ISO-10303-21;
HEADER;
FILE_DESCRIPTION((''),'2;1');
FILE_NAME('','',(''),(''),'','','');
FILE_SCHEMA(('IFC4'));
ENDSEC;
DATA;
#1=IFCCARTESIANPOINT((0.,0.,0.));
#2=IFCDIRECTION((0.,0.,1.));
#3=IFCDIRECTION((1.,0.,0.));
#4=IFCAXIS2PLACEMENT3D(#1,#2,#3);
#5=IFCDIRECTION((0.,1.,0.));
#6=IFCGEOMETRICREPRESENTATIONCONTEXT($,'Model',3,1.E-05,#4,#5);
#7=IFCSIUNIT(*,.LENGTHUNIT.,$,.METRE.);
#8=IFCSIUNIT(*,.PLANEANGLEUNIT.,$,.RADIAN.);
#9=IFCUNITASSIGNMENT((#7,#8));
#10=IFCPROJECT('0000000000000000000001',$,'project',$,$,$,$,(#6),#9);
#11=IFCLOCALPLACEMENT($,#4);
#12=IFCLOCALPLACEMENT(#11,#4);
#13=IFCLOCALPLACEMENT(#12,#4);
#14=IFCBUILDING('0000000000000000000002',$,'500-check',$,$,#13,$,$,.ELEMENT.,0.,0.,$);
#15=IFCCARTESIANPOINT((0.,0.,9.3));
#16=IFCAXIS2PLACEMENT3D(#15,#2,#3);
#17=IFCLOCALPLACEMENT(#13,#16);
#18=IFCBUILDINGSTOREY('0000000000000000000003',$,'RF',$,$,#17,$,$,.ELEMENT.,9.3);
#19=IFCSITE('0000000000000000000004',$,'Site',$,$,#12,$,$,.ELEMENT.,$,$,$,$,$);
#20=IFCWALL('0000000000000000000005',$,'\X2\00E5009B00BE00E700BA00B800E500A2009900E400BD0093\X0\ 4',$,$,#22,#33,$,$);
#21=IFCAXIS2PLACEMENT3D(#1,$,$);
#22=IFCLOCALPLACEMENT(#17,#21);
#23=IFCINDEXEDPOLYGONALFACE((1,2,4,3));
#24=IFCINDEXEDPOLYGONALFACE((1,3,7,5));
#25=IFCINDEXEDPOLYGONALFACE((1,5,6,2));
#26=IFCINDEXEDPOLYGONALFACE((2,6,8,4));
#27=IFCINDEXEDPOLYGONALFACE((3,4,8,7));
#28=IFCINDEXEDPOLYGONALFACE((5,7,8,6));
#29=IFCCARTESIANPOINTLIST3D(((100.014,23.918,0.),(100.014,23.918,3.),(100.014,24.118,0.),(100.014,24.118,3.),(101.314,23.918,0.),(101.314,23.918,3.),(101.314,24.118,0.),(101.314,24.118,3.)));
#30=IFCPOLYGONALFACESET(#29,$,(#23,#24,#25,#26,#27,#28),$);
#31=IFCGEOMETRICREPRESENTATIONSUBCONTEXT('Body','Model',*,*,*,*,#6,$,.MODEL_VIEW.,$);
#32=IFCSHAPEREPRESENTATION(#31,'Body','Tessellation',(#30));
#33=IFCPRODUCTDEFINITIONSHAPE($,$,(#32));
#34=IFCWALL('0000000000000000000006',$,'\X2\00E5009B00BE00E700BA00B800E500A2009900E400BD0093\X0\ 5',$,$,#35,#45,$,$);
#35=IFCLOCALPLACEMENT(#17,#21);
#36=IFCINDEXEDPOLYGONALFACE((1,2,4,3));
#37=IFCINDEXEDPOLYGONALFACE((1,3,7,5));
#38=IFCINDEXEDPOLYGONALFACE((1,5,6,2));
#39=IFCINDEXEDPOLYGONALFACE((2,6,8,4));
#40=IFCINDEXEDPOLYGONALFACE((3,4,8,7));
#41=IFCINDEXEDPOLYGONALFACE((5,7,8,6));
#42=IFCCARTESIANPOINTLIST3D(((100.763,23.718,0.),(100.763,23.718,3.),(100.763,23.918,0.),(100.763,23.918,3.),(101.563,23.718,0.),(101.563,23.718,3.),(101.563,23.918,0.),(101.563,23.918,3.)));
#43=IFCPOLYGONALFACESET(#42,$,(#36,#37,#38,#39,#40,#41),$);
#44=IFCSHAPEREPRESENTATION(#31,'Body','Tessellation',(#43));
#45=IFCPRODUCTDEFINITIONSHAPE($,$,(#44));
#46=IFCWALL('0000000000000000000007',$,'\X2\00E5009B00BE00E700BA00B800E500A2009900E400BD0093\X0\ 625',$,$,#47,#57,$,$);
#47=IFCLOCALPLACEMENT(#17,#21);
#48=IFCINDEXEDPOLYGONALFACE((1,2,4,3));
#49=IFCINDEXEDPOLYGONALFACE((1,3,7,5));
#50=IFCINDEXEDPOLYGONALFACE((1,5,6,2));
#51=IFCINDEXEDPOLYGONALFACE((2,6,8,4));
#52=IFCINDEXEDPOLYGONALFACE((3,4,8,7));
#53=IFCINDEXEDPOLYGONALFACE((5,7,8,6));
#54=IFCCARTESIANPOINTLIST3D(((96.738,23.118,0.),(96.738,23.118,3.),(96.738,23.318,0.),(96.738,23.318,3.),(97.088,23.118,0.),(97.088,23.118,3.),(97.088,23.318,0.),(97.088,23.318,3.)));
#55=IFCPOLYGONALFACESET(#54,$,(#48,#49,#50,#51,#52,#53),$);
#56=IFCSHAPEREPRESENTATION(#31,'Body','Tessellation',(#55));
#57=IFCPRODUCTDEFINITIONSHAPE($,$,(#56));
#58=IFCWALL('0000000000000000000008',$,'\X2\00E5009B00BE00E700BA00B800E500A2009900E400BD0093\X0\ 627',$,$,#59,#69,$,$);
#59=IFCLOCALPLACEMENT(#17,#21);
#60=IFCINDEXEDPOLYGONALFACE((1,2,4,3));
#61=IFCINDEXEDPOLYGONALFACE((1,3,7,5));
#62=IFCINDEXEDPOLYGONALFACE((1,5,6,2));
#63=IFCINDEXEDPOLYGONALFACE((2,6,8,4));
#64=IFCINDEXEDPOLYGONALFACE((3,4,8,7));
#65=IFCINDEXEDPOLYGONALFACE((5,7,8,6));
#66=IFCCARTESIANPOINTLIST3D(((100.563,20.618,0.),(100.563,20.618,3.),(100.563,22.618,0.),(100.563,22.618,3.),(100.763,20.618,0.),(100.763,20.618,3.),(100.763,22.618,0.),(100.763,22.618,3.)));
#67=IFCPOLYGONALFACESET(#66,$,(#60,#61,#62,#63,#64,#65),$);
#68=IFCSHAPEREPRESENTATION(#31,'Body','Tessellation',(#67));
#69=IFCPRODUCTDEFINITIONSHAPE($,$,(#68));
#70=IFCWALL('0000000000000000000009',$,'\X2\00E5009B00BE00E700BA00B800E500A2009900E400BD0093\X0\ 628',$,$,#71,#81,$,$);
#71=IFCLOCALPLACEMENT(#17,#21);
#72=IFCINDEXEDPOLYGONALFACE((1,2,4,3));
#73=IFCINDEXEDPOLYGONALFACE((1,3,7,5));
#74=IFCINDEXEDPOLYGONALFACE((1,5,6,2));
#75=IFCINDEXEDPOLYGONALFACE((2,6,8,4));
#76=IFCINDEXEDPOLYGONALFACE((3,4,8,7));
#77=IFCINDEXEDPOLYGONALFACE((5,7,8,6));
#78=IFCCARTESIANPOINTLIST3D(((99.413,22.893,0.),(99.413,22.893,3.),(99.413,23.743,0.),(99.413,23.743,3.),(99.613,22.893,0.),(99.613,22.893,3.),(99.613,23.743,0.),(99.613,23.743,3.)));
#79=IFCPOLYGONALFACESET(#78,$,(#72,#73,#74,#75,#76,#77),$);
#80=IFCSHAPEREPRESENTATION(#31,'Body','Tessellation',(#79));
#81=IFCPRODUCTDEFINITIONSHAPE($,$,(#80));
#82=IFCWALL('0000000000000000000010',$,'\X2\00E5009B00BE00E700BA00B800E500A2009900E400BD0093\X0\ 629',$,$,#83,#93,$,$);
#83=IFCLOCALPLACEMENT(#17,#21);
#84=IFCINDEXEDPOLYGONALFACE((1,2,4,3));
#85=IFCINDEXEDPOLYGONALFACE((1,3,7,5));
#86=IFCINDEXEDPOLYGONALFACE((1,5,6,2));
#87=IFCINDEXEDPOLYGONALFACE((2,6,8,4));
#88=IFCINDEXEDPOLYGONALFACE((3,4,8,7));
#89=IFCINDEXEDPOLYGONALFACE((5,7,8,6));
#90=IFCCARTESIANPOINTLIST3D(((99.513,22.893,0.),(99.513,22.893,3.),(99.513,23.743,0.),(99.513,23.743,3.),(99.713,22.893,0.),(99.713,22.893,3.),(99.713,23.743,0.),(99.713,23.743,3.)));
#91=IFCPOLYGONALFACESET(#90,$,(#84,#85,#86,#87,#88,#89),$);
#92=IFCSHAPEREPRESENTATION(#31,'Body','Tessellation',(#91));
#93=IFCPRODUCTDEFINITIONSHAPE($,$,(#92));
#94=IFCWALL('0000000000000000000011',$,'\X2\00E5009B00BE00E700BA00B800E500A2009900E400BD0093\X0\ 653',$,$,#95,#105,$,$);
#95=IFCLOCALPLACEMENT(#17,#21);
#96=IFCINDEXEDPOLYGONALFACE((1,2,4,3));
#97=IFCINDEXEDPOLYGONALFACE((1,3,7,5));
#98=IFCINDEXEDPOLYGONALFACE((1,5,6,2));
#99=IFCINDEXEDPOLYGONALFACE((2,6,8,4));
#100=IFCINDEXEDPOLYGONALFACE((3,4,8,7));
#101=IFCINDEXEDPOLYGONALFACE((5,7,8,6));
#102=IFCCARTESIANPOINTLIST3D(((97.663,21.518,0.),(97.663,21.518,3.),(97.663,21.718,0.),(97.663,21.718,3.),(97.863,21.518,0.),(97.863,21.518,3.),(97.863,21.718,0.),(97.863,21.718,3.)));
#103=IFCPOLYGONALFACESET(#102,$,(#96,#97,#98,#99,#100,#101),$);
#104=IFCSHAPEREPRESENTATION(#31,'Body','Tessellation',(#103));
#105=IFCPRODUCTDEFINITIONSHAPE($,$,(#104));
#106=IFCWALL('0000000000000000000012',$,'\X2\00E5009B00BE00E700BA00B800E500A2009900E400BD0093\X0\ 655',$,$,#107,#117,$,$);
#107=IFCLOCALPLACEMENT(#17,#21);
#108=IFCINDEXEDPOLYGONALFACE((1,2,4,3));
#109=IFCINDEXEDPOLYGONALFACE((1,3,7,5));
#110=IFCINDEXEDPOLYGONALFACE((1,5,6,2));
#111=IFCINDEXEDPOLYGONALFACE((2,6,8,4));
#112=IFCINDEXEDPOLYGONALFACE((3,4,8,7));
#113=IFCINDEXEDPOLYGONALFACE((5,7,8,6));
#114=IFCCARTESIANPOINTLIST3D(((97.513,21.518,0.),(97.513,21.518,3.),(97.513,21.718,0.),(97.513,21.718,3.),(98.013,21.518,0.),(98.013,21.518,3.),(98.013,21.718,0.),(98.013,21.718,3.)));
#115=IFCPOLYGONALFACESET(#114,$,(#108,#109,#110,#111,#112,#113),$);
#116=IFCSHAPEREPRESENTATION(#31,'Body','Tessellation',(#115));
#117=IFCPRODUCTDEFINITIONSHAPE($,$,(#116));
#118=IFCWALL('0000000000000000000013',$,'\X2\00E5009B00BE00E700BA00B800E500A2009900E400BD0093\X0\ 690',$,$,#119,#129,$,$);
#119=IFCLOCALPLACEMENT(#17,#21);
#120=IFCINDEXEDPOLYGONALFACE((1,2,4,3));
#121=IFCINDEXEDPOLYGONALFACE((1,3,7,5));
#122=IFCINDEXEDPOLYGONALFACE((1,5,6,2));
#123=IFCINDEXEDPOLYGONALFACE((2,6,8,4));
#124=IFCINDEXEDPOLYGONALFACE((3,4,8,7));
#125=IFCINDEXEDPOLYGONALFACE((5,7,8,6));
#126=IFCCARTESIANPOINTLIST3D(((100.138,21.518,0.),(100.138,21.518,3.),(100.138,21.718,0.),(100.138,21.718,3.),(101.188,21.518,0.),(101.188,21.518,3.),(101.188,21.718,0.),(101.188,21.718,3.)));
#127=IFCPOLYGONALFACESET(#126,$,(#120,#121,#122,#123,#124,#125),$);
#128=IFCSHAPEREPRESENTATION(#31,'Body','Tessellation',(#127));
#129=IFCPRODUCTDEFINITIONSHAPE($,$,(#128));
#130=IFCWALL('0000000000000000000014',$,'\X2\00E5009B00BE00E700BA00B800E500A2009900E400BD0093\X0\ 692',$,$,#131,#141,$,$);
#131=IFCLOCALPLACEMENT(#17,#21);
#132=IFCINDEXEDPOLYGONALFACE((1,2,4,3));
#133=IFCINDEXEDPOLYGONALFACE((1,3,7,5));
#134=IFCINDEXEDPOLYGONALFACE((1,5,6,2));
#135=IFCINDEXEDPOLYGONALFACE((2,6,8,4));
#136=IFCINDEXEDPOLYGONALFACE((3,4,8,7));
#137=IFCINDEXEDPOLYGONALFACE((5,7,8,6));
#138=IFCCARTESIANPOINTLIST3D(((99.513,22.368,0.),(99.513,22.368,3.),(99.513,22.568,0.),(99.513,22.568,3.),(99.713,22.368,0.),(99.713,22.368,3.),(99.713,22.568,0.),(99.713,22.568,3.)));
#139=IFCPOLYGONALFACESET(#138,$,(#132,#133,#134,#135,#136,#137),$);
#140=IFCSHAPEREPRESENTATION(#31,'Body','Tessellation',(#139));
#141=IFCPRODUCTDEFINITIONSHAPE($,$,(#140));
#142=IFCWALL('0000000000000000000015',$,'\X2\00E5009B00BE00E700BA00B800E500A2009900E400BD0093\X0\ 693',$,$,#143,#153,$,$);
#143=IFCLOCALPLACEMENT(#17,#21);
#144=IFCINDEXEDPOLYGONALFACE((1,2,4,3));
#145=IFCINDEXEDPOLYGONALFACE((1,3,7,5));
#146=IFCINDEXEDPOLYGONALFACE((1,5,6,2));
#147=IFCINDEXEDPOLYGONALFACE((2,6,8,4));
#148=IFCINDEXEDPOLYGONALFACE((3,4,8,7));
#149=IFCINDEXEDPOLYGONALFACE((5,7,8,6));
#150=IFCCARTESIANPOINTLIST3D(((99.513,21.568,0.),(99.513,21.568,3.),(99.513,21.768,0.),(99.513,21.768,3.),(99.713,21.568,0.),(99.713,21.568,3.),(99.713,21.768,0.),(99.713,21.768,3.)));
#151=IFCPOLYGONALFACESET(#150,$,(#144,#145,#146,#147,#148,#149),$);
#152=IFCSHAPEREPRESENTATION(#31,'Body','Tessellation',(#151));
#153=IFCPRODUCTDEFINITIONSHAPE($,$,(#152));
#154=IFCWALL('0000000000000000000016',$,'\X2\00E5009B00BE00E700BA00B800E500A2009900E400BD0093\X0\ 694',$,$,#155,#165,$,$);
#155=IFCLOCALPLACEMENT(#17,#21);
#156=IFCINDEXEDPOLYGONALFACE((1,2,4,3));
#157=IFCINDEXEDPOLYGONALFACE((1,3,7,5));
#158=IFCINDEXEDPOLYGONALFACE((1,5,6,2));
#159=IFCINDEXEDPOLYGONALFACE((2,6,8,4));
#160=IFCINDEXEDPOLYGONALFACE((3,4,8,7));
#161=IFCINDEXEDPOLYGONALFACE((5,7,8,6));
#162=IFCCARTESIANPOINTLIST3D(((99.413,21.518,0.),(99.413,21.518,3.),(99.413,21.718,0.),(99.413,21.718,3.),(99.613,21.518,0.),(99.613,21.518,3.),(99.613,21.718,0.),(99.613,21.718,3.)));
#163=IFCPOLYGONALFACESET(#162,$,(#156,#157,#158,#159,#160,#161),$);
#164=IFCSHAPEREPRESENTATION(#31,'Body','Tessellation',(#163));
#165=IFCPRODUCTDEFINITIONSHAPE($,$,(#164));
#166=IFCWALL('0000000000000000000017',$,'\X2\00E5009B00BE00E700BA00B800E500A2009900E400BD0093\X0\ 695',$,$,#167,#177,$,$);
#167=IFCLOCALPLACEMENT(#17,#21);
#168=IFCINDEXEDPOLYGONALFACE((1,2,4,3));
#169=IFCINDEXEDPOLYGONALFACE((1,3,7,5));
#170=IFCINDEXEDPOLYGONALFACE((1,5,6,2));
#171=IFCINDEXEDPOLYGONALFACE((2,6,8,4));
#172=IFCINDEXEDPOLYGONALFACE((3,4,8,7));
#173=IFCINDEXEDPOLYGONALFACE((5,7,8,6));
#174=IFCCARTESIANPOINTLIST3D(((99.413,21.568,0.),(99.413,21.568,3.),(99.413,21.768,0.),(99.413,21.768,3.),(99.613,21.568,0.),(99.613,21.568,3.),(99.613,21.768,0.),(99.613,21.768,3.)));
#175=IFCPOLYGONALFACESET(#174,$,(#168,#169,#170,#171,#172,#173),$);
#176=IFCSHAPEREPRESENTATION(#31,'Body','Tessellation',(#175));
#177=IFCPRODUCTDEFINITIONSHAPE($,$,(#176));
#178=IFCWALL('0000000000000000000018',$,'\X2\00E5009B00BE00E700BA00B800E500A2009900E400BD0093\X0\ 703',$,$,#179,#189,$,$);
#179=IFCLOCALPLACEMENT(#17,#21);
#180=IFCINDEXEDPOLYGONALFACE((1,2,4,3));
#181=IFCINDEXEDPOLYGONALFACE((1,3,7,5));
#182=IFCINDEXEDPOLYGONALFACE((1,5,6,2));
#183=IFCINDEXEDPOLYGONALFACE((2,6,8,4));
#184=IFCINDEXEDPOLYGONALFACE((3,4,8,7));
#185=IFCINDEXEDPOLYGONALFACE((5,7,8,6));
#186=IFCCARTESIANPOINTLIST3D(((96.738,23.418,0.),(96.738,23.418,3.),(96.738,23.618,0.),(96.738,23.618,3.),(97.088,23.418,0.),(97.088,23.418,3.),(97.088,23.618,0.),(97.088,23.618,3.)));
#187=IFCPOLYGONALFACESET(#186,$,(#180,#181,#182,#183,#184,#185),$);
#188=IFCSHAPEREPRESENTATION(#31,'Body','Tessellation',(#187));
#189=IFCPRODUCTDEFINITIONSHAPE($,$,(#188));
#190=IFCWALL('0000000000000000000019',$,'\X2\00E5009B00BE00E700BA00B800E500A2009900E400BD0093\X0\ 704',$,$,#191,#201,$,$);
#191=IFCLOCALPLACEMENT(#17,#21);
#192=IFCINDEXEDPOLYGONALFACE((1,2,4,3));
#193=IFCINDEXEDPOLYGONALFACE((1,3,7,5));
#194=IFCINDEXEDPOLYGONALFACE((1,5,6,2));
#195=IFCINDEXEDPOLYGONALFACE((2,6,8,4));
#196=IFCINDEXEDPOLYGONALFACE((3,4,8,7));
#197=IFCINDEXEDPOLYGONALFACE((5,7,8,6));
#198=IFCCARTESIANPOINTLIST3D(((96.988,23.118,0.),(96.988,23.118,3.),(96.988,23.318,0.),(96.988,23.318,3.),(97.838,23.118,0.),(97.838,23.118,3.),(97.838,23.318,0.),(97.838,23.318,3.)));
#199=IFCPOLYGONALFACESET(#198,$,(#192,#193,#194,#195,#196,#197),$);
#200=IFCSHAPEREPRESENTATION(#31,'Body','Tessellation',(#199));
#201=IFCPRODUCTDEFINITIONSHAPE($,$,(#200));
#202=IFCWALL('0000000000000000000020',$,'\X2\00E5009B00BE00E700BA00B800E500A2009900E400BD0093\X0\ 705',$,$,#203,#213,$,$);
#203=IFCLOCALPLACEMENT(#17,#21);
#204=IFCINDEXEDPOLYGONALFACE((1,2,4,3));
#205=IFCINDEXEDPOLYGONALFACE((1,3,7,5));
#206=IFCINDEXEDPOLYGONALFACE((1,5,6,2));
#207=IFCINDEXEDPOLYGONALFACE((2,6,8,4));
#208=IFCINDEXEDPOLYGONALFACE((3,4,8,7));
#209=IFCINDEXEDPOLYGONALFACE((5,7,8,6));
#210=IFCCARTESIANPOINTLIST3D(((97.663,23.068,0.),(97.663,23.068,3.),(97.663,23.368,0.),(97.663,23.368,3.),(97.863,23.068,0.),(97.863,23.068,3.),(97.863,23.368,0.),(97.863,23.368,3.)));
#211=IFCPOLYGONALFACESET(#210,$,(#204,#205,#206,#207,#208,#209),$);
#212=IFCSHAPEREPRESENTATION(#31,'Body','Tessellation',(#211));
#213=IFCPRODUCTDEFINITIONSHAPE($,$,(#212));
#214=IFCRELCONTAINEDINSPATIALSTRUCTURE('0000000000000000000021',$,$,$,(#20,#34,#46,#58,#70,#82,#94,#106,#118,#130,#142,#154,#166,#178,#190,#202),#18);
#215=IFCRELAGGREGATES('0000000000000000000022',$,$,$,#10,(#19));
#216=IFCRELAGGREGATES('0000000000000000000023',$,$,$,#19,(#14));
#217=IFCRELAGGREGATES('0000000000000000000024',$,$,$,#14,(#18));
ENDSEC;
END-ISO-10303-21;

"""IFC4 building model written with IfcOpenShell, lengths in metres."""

from ifc_helpers import new_model, si_unit, direction, frame, frame_2d, origin_with_axes, place, context, subcontext, project, spatial, rectangle, extrude, element, save


model = new_model("IFC4")

# Units and contexts
model_context = context("Model", 3, precision=1e-05, world=origin_with_axes(), true_north=direction((0.0, 1.0, 0.0)))
body_context = subcontext(model_context, "Body", "Model", "MODEL_VIEW")
ifc_project = project(units=[si_unit("LENGTHUNIT", "METRE"), si_unit("PLANEANGLEUNIT", "RADIAN")], contexts=[model_context])

# Site, building, storey
placement = place(None, origin_with_axes())
site_placement = place(placement, origin_with_axes())
site = spatial("IfcSite", under=ifc_project, at=site_placement, Name="Site", CompositionType="ELEMENT")
building_placement = place(site_placement, origin_with_axes())
building = spatial("IfcBuilding", under=site, at=building_placement, Name="500-check", CompositionType="ELEMENT", ElevationOfRefHeight=0.0, ElevationOfTerrain=0.0)
storey_placement = place(building_placement, frame((0.0, 0.0, 9.3), z_axis=(0.0, 0.0, 1.0), x_axis=(1.0, 0.0, 0.0)))
storey = spatial("IfcBuildingStorey", under=building, at=storey_placement, Name="RF", CompositionType="ELEMENT", Elevation=9.3)

# Walls
wall_1_placement = place(storey_placement, frame((100.664, 24.018, 0.0), z_axis=(0.0, 0.0, 1.0), x_axis=(1.0, 0.0, 0.0)))
element("IfcWall", 1, at=wall_1_placement, inside=storey, Name="å\u009b¾çº¸å¢\u0099ä½\u0093 4", context=body_context, shape_type="SweptSolid", body=[
    extrude(rectangle(XDim=1.3, YDim=0.2, at=frame_2d((0.0, 0.0), x_axis=(1.0, 0.0, 0.0))), frame((0.0, 0.0, 0.0), z_axis=(0.0, 0.0, 1.0)), (0.0, 0.0, 1.0), 3.0),
])
wall_2_placement = place(storey_placement, frame((101.163, 23.818, 0.0), z_axis=(0.0, 0.0, 1.0), x_axis=(1.0, 0.0, 0.0)))
element("IfcWall", 2, at=wall_2_placement, inside=storey, Name="å\u009b¾çº¸å¢\u0099ä½\u0093 5", context=body_context, shape_type="SweptSolid", body=[
    extrude(rectangle(XDim=0.8, YDim=0.2, at=frame_2d((0.0, 0.0), x_axis=(1.0, 0.0, 0.0))), frame((0.0, 0.0, 0.0), z_axis=(0.0, 0.0, 1.0)), (0.0, 0.0, 1.0), 3.0),
])
wall_3_placement = place(storey_placement, frame((96.913, 23.218, 0.0), z_axis=(0.0, 0.0, 1.0), x_axis=(-1.0, 0.0, 0.0)))
element("IfcWall", 3, at=wall_3_placement, inside=storey, Name="å\u009b¾çº¸å¢\u0099ä½\u0093 625", context=body_context, shape_type="SweptSolid", body=[
    extrude(rectangle(XDim=0.35, YDim=0.2, at=frame_2d((0.0, 0.0), x_axis=(1.0, 0.0, 0.0))), frame((0.0, 0.0, 0.0), z_axis=(0.0, 0.0, 1.0)), (0.0, 0.0, 1.0), 3.0),
])
wall_4_placement = place(storey_placement, frame((100.663, 21.618, 0.0), z_axis=(0.0, 0.0, 1.0), x_axis=(0.0, 1.0, 0.0)))
element("IfcWall", 4, at=wall_4_placement, inside=storey, Name="å\u009b¾çº¸å¢\u0099ä½\u0093 627", context=body_context, shape_type="SweptSolid", body=[
    extrude(rectangle(XDim=2.0, YDim=0.2, at=frame_2d((0.0, 0.0), x_axis=(1.0, 0.0, 0.0))), frame((0.0, 0.0, 0.0), z_axis=(0.0, 0.0, 1.0)), (0.0, 0.0, 1.0), 3.0),
])
for number, where, z_axis, x_axis, name in (
    (5, (99.513, 23.318, 0.0), (0.0, 0.0, 1.0), (0.0, -1.0, 0.0), "å\u009b¾çº¸å¢\u0099ä½\u0093 628"),
    (6, (99.613, 23.318, 0.0), (0.0, 0.0, 1.0), (0.0, -1.0, 0.0), "å\u009b¾çº¸å¢\u0099ä½\u0093 629"),
):
    element("IfcWall", number, at=place(storey_placement, frame(where, z_axis=z_axis, x_axis=x_axis)), inside=storey, Name=name, context=body_context, shape_type="SweptSolid", body=[
        extrude(rectangle(XDim=0.85, YDim=0.2, at=frame_2d((0.0, 0.0), x_axis=(1.0, 0.0, 0.0))), frame((0.0, 0.0, 0.0), z_axis=(0.0, 0.0, 1.0)), (0.0, 0.0, 1.0), 3.0),
    ])
wall_5_placement = place(storey_placement, frame((97.763, 21.618, 0.0), z_axis=(0.0, 0.0, 1.0), x_axis=(0.0, -1.0, 0.0)))
element("IfcWall", 7, at=wall_5_placement, inside=storey, Name="å\u009b¾çº¸å¢\u0099ä½\u0093 653", context=body_context, shape_type="SweptSolid", body=[
    extrude(rectangle(XDim=0.2, YDim=0.2, at=frame_2d((0.0, 0.0), x_axis=(1.0, 0.0, 0.0))), frame((0.0, 0.0, 0.0), z_axis=(0.0, 0.0, 1.0)), (0.0, 0.0, 1.0), 3.0),
])
wall_6_placement = place(storey_placement, frame((97.763, 21.618, 0.0), z_axis=(0.0, 0.0, 1.0), x_axis=(-1.0, 0.0, 0.0)))
element("IfcWall", 8, at=wall_6_placement, inside=storey, Name="å\u009b¾çº¸å¢\u0099ä½\u0093 655", context=body_context, shape_type="SweptSolid", body=[
    extrude(rectangle(XDim=0.5, YDim=0.2, at=frame_2d((0.0, 0.0), x_axis=(1.0, 0.0, 0.0))), frame((0.0, 0.0, 0.0), z_axis=(0.0, 0.0, 1.0)), (0.0, 0.0, 1.0), 3.0),
])
wall_7_placement = place(storey_placement, frame((100.663, 21.618, 0.0), z_axis=(0.0, 0.0, 1.0), x_axis=(-1.0, 0.0, 0.0)))
element("IfcWall", 9, at=wall_7_placement, inside=storey, Name="å\u009b¾çº¸å¢\u0099ä½\u0093 690", context=body_context, shape_type="SweptSolid", body=[
    extrude(rectangle(XDim=1.05, YDim=0.2, at=frame_2d((0.0, 0.0), x_axis=(1.0, 0.0, 0.0))), frame((0.0, 0.0, 0.0), z_axis=(0.0, 0.0, 1.0)), (0.0, 0.0, 1.0), 3.0),
])
for number, where, z_axis, x_axis, name in (
    (10, (99.613, 22.468, 0.0), (0.0, 0.0, 1.0), (-1.0, 0.0, 0.0), "å\u009b¾çº¸å¢\u0099ä½\u0093 692"),
    (11, (99.613, 21.668, 0.0), (0.0, 0.0, 1.0), (-1.0, 0.0, 0.0), "å\u009b¾çº¸å¢\u0099ä½\u0093 693"),
    (12, (99.513, 21.618, 0.0), (0.0, 0.0, 1.0), (0.0, -1.0, 0.0), "å\u009b¾çº¸å¢\u0099ä½\u0093 694"),
    (13, (99.513, 21.668, 0.0), (0.0, 0.0, 1.0), (0.0, -1.0, 0.0), "å\u009b¾çº¸å¢\u0099ä½\u0093 695"),
):
    element("IfcWall", number, at=place(storey_placement, frame(where, z_axis=z_axis, x_axis=x_axis)), inside=storey, Name=name, context=body_context, shape_type="SweptSolid", body=[
        extrude(rectangle(XDim=0.2, YDim=0.2, at=frame_2d((0.0, 0.0), x_axis=(1.0, 0.0, 0.0))), frame((0.0, 0.0, 0.0), z_axis=(0.0, 0.0, 1.0)), (0.0, 0.0, 1.0), 3.0),
    ])
wall_8_placement = place(storey_placement, frame((96.913, 23.518, 0.0), z_axis=(0.0, 0.0, 1.0), x_axis=(-1.0, 0.0, 0.0)))
element("IfcWall", 14, at=wall_8_placement, inside=storey, Name="å\u009b¾çº¸å¢\u0099ä½\u0093 703", context=body_context, shape_type="SweptSolid", body=[
    extrude(rectangle(XDim=0.35, YDim=0.2, at=frame_2d((0.0, 0.0), x_axis=(1.0, 0.0, 0.0))), frame((0.0, 0.0, 0.0), z_axis=(0.0, 0.0, 1.0)), (0.0, 0.0, 1.0), 3.0),
])
wall_9_placement = place(storey_placement, frame((97.413, 23.218, 0.0), z_axis=(0.0, 0.0, 1.0), x_axis=(-1.0, 0.0, 0.0)))
element("IfcWall", 15, at=wall_9_placement, inside=storey, Name="å\u009b¾çº¸å¢\u0099ä½\u0093 704", context=body_context, shape_type="SweptSolid", body=[
    extrude(rectangle(XDim=0.85, YDim=0.2, at=frame_2d((0.0, 0.0), x_axis=(1.0, 0.0, 0.0))), frame((0.0, 0.0, 0.0), z_axis=(0.0, 0.0, 1.0)), (0.0, 0.0, 1.0), 3.0),
])
wall_10_placement = place(storey_placement, frame((97.763, 23.218, 0.0), z_axis=(0.0, 0.0, 1.0), x_axis=(0.0, 1.0, 0.0)))
element("IfcWall", 16, at=wall_10_placement, inside=storey, Name="å\u009b¾çº¸å¢\u0099ä½\u0093 705", context=body_context, shape_type="SweptSolid", body=[
    extrude(rectangle(XDim=0.3, YDim=0.2, at=frame_2d((0.0, 0.0), x_axis=(1.0, 0.0, 0.0))), frame((0.0, 0.0, 0.0), z_axis=(0.0, 0.0, 1.0)), (0.0, 0.0, 1.0), 3.0),
])

save(model, "model.ifc")
